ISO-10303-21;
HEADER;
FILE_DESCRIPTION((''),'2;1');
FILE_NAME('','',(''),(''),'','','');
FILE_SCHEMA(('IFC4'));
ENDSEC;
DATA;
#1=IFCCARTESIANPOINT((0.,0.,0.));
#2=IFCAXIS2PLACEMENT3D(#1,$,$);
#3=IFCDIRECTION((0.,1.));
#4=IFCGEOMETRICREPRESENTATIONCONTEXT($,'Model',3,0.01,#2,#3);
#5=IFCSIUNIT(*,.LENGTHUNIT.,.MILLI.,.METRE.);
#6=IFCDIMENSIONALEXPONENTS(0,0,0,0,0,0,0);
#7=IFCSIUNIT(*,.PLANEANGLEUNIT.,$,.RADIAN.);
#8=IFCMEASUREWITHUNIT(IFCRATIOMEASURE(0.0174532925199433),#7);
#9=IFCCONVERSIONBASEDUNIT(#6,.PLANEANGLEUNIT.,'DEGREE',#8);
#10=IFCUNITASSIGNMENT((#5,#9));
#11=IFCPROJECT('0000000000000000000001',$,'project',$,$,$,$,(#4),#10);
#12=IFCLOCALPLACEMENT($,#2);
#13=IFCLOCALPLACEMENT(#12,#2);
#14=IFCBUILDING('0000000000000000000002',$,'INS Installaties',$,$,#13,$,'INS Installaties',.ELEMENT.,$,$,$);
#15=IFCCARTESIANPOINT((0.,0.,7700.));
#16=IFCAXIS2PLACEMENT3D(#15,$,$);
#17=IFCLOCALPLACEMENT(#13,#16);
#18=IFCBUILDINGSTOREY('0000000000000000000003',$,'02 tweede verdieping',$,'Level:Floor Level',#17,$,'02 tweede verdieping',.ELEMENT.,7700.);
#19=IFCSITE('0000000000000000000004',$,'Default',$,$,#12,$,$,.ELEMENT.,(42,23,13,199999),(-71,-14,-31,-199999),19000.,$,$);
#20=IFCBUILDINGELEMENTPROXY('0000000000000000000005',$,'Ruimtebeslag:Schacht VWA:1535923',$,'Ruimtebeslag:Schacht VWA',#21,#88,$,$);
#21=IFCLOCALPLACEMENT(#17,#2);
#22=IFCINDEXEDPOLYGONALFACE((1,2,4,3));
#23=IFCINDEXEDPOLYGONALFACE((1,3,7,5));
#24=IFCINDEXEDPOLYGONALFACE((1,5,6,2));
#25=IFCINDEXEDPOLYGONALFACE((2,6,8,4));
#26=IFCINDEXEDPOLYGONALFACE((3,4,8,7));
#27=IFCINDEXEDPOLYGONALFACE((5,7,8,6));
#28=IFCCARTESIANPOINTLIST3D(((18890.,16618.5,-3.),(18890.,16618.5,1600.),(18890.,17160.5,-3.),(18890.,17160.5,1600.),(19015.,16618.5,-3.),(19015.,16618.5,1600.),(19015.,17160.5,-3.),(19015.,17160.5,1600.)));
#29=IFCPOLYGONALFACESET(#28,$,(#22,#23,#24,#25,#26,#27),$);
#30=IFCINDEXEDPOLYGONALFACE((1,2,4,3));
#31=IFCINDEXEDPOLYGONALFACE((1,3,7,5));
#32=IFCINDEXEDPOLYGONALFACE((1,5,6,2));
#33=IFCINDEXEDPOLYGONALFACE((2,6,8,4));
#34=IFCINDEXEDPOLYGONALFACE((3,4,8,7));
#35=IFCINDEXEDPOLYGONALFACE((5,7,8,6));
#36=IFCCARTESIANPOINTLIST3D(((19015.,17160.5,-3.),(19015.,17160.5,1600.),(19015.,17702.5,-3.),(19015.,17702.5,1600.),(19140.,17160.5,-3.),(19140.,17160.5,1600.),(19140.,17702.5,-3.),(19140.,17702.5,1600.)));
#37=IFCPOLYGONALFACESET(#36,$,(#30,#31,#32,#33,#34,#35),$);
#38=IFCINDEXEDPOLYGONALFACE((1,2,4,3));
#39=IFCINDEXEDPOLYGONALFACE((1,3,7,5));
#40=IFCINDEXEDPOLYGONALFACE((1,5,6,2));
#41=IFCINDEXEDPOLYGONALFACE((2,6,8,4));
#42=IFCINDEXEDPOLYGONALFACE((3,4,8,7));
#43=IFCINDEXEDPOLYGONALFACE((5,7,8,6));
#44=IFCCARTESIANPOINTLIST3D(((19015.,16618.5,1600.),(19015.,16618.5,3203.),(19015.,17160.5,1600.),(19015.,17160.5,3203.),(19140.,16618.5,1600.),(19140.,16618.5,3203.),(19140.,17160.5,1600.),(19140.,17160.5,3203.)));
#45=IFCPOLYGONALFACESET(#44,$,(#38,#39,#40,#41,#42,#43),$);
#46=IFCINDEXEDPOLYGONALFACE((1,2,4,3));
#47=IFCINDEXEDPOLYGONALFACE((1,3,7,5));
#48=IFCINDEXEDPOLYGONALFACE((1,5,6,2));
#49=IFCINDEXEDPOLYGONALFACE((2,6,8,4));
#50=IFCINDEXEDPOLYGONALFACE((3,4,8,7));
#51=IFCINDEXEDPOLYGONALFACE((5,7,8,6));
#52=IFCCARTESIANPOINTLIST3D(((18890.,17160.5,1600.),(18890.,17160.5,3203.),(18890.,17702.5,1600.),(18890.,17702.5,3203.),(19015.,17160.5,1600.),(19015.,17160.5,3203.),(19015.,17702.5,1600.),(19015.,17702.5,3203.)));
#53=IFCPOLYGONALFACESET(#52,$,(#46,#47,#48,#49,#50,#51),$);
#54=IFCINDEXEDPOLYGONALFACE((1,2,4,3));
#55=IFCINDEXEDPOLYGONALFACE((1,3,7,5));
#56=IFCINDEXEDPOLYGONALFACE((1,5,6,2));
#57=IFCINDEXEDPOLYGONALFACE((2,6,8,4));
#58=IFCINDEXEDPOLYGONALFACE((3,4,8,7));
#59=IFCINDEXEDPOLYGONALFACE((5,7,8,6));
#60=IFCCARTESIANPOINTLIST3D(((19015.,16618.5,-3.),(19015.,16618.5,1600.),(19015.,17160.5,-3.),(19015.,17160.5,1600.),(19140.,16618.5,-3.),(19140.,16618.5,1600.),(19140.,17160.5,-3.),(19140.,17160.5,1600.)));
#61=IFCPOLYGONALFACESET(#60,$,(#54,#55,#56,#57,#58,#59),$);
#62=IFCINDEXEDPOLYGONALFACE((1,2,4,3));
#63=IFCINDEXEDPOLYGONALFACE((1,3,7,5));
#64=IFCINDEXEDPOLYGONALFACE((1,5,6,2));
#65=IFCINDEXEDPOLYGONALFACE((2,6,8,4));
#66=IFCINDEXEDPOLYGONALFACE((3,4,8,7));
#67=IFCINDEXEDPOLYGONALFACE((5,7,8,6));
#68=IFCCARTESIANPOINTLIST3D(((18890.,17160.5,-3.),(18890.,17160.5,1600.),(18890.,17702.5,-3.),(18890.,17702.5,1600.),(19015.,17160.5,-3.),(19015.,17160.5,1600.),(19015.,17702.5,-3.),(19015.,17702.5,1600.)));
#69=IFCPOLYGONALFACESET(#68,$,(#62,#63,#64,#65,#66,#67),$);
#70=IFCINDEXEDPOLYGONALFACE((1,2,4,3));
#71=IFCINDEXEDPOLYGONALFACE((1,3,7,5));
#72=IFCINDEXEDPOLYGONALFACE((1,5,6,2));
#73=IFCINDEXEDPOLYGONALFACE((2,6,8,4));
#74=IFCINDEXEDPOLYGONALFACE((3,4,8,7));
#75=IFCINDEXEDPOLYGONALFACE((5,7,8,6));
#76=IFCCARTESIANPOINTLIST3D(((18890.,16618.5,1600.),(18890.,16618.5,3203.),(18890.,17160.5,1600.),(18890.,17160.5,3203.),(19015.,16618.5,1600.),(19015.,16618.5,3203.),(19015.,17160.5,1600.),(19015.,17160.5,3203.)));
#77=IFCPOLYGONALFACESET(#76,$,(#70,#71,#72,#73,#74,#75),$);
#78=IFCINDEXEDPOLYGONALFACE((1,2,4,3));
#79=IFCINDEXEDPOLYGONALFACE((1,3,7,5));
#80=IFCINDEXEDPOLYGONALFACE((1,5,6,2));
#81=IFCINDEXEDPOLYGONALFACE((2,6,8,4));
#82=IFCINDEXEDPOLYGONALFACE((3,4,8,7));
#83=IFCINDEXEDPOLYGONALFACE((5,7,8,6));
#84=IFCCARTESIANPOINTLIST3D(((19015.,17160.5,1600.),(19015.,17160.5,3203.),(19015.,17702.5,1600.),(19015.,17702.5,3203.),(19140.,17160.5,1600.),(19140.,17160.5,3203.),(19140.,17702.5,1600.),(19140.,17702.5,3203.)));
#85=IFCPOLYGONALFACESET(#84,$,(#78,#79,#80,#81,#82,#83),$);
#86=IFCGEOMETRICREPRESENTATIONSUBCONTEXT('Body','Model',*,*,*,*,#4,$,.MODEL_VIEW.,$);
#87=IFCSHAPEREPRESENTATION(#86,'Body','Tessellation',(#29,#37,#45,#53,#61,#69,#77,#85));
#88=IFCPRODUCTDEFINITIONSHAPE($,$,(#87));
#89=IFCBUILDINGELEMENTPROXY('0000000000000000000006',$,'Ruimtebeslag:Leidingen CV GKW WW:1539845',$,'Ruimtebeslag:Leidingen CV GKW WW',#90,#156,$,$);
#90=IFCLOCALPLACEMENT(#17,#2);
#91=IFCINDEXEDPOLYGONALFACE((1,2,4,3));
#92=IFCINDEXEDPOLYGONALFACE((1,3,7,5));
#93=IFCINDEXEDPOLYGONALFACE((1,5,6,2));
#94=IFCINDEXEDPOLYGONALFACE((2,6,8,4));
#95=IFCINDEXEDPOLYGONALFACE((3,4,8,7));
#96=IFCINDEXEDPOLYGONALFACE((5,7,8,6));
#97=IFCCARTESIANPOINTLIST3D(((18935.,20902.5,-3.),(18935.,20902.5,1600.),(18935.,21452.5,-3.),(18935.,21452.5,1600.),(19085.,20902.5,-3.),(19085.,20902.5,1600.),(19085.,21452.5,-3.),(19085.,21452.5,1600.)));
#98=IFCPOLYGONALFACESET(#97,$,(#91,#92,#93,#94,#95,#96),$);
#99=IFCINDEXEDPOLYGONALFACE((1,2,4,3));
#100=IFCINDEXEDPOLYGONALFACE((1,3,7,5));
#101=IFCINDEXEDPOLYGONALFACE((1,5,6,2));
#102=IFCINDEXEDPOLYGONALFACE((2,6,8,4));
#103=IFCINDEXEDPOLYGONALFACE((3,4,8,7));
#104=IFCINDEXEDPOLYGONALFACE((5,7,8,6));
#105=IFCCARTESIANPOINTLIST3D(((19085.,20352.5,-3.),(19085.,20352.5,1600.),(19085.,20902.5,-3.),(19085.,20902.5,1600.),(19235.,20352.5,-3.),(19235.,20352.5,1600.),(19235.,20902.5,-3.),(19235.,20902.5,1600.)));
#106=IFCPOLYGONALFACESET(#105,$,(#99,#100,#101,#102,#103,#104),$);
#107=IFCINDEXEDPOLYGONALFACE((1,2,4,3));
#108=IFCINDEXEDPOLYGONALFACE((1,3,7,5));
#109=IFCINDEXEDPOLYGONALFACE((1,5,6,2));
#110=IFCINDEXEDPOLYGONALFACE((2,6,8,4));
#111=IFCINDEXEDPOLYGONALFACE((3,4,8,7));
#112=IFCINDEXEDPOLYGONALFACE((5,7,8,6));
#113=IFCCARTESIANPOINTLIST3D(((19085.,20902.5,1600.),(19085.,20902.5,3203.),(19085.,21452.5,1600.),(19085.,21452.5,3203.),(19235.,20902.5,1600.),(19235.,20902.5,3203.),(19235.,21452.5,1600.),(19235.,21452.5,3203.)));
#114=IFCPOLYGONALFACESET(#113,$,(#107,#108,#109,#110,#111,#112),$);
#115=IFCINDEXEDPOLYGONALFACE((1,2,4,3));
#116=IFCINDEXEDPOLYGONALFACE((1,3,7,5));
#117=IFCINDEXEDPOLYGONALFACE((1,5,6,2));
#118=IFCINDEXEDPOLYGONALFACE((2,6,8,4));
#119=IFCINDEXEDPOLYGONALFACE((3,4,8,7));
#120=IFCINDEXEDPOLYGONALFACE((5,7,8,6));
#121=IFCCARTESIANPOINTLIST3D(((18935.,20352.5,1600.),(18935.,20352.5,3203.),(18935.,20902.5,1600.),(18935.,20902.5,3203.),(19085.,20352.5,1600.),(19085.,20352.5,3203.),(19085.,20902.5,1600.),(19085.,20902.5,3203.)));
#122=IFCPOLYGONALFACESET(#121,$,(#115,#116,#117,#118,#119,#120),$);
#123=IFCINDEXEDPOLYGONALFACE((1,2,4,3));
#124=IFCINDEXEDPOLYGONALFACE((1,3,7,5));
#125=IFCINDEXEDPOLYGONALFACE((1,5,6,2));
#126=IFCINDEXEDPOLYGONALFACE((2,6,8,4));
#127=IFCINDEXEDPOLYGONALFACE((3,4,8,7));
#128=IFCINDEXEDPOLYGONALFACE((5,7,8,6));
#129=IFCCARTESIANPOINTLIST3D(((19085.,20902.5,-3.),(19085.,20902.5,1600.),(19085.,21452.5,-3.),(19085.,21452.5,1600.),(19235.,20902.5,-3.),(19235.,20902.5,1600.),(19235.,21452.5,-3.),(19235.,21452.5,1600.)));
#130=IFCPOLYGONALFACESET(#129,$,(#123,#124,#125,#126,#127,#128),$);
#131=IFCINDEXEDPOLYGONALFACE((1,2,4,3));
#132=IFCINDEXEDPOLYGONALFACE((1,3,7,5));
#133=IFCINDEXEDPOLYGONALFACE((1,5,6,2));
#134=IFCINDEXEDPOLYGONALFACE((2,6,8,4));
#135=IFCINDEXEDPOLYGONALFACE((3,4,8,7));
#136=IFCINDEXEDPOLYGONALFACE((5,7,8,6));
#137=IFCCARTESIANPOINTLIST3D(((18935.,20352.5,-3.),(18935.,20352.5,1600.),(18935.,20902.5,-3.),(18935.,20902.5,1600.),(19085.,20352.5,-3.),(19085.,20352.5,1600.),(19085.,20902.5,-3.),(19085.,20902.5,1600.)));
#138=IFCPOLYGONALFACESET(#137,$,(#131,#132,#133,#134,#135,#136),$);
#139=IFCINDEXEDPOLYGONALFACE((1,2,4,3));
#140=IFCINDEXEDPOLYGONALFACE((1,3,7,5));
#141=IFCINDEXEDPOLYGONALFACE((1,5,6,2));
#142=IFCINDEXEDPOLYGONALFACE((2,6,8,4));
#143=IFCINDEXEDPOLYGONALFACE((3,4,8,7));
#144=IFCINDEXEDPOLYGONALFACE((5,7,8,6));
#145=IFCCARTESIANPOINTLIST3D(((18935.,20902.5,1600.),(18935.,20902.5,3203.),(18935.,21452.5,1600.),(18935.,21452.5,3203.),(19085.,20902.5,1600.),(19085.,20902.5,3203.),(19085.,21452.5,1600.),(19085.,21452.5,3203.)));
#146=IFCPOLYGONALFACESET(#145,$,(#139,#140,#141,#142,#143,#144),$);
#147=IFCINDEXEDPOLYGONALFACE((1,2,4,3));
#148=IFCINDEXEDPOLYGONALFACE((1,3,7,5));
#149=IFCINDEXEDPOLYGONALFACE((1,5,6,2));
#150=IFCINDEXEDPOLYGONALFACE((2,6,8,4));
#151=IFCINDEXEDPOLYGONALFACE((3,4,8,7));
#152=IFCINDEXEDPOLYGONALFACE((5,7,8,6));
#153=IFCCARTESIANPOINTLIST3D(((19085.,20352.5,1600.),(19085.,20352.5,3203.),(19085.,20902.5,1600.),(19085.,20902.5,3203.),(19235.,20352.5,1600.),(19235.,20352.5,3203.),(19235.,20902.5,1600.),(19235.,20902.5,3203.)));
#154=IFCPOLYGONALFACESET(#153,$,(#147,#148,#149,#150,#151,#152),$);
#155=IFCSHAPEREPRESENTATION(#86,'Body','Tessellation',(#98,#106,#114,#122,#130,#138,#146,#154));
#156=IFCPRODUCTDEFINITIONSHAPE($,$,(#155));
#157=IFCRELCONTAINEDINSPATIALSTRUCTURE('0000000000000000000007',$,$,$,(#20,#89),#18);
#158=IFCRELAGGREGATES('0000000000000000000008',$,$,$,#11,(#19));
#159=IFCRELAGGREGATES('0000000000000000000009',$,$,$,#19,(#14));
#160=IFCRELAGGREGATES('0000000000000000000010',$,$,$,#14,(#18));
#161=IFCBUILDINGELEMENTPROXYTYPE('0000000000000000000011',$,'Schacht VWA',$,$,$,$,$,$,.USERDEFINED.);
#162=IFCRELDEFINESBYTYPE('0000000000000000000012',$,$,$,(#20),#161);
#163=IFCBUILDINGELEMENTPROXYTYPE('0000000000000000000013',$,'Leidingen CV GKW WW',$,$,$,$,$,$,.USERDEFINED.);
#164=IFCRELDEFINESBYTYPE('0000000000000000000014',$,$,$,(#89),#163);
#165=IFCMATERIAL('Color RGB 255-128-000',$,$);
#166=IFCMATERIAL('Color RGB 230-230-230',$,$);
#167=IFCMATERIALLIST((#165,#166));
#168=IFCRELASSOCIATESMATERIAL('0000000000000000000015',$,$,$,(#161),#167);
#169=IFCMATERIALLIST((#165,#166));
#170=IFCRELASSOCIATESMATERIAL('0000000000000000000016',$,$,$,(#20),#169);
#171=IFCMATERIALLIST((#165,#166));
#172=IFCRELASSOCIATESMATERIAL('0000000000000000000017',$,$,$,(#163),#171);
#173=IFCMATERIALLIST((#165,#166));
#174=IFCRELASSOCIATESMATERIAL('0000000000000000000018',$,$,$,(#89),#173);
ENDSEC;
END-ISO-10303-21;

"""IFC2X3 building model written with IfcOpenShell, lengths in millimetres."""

from ifc_helpers import new_model, entity, si_unit, converted_unit, direction, frame, frame_2d, origin, origin_2d_with_axis, place, context, subcontext, project, spatial, rectangle, extrude, source, transform, mapped, material, material_list, type_object, type_shapes, element, save


model = new_model("IFC2X3")

# Units and contexts
model_context = context("Model", 3, precision=0.01, world=origin(), true_north=direction((0.0, 1.0)))
body_context = subcontext(model_context, "Body", "Model", "MODEL_VIEW")
ifc_project = project(units=[si_unit("LENGTHUNIT", "METRE", prefix="MILLI"), converted_unit("PLANEANGLEUNIT", "DEGREE", entity("IfcRatioMeasure", 0.0174532925199433), si_unit("PLANEANGLEUNIT", "RADIAN"), dimensions=[0, 0, 0, 0, 0, 0, 0])], contexts=[model_context])

# Site, building, storey
site_placement = place(None, origin())
site = spatial("IfcSite", under=ifc_project, at=site_placement, Name="Default", CompositionType="ELEMENT", RefLatitude=(42, 23, 13, 199999), RefLongitude=(-71, -14, -31, -199999), RefElevation=19000.0)
building_placement = place(site_placement, origin())
building = spatial("IfcBuilding", under=site, at=building_placement, Name="INS Installaties", LongName="INS Installaties", CompositionType="ELEMENT")
storey_placement = place(building_placement, frame((0.0, 0.0, 7700.0)))
storey = spatial("IfcBuildingStorey", under=building, at=storey_placement, Name="02 tweede verdieping", ObjectType="Level:Floor Level", LongName="02 tweede verdieping", CompositionType="ELEMENT", Elevation=7700.0)

# Building element proxies
ifc_material_1 = material(Name="Color RGB 255-128-000")
ifc_material_2 = material(Name="Color RGB 230-230-230")
ifc_material_list_1 = material_list([ifc_material_1, ifc_material_2])
ifc_material_list_2 = material_list([ifc_material_1, ifc_material_2])
building_element_proxy_type_1 = type_object("IfcBuildingElementProxyType", Name="Schacht VWA", PredefinedType="USERDEFINED", material=ifc_material_list_2)
shared_shape_1 = source(origin(), body_context, "Body", "SweptSolid", [
    extrude(rectangle(XDim=542.0, YDim=125.0, at=frame_2d((0.0, 0.0), x_axis=(1.0, 0.0))), frame((62.5, 271.0, -3203.0), z_axis=(0.0, 0.0, 1.0), x_axis=(0.0, -1.0, 0.0)), (0.0, 0.0, 1.0), 1603.0),
    extrude(rectangle(XDim=542.0, YDim=125.0, at=origin_2d_with_axis()), frame((-62.5, -271.0, -3203.0), z_axis=(0.0, 0.0, 1.0), x_axis=(0.0, 1.0, 0.0)), (0.0, 0.0, 1.0), 1603.0),
    extrude(rectangle(XDim=125.0, YDim=542.0, at=frame_2d((0.0, 0.0), x_axis=(1.0, 0.0))), frame((-62.5, 271.0, -1600.0), z_axis=(0.0, 0.0, 1.0), x_axis=(-1.0, 0.0, 0.0)), (0.0, 0.0, 1.0), 1603.0),
    extrude(rectangle(XDim=125.0, YDim=542.0, at=frame_2d((0.0, 0.0), x_axis=(1.0, 0.0))), frame((62.5, -271.0, -1600.0)), (0.0, 0.0, 1.0), 1603.0),
    extrude(rectangle(XDim=125.0, YDim=542.0, at=frame_2d((0.0, 0.0), x_axis=(1.0, 0.0))), frame((-62.5, 271.0, -3203.0), z_axis=(0.0, 0.0, 1.0), x_axis=(-1.0, 0.0, 0.0)), (0.0, 0.0, 1.0), 1603.0),
    extrude(rectangle(XDim=125.0, YDim=542.0, at=frame_2d((0.0, 0.0), x_axis=(1.0, 0.0))), frame((62.5, -271.0, -3203.0)), (0.0, 0.0, 1.0), 1603.0),
    extrude(rectangle(XDim=542.0, YDim=125.0, at=origin_2d_with_axis()), frame((62.5, 271.0, -1600.0), z_axis=(0.0, 0.0, 1.0), x_axis=(0.0, -1.0, 0.0)), (0.0, 0.0, 1.0), 1603.0),
    extrude(rectangle(XDim=542.0, YDim=125.0, at=origin_2d_with_axis()), frame((-62.5, -271.0, -1600.0), z_axis=(0.0, 0.0, 1.0), x_axis=(0.0, 1.0, 0.0)), (0.0, 0.0, 1.0), 1603.0),
])
type_shapes(building_element_proxy_type_1, [shared_shape_1])
proxy_1_placement = place(storey_placement, frame((19015.0, 17160.5, 3200.0), z_axis=(0.0, 0.0, 1.0), x_axis=(-1.0, 0.0, 0.0)))
element("IfcBuildingElementProxy", 1, at=proxy_1_placement, inside=storey, type_object=building_element_proxy_type_1, material=ifc_material_list_1, Name="Ruimtebeslag:Schacht VWA:1535923", ObjectType="Ruimtebeslag:Schacht VWA", context=body_context, shape_type="MappedRepresentation", body=[
    mapped(shared_shape_1, transform((0.0, 0.0, 0.0), scale=1.0)),
])
ifc_material_list_3 = material_list([ifc_material_1, ifc_material_2])
ifc_material_list_4 = material_list([ifc_material_1, ifc_material_2])
building_element_proxy_type_2 = type_object("IfcBuildingElementProxyType", Name="Leidingen CV GKW WW", PredefinedType="USERDEFINED", material=ifc_material_list_4)
shared_shape_2 = source(origin(), body_context, "Body", "SweptSolid", [
    extrude(rectangle(XDim=150.0, YDim=550.0, at=frame_2d((0.0, 0.0), x_axis=(1.0, 0.0))), frame((75.0, -275.0, -3203.0)), (0.0, 0.0, 1.0), 1603.0),
    extrude(rectangle(XDim=150.0, YDim=550.0, at=origin_2d_with_axis()), frame((-75.0, 275.0, -3203.0), z_axis=(0.0, 0.0, 1.0), x_axis=(-1.0, 0.0, 0.0)), (0.0, 0.0, 1.0), 1603.0),
    extrude(rectangle(XDim=550.0, YDim=150.0, at=frame_2d((0.0, 0.0), x_axis=(1.0, 0.0))), frame((-75.0, -275.0, -1600.0), z_axis=(0.0, 0.0, 1.0), x_axis=(0.0, 1.0, 0.0)), (0.0, 0.0, 1.0), 1603.0),
    extrude(rectangle(XDim=550.0, YDim=150.0, at=origin_2d_with_axis()), frame((75.0, 275.0, -1600.0), z_axis=(0.0, 0.0, 1.0), x_axis=(0.0, -1.0, 0.0)), (0.0, 0.0, 1.0), 1603.0),
    extrude(rectangle(XDim=550.0, YDim=150.0, at=origin_2d_with_axis()), frame((-75.0, -275.0, -3203.0), z_axis=(0.0, 0.0, 1.0), x_axis=(0.0, 1.0, 0.0)), (0.0, 0.0, 1.0), 1603.0),
    extrude(rectangle(XDim=550.0, YDim=150.0, at=origin_2d_with_axis()), frame((75.0, 275.0, -3203.0), z_axis=(0.0, 0.0, 1.0), x_axis=(0.0, -1.0, 0.0)), (0.0, 0.0, 1.0), 1603.0),
    extrude(rectangle(XDim=150.0, YDim=550.0, at=frame_2d((0.0, 0.0), x_axis=(1.0, 0.0))), frame((75.0, -275.0, -1600.0)), (0.0, 0.0, 1.0), 1603.0),
    extrude(rectangle(XDim=150.0, YDim=550.0, at=origin_2d_with_axis()), frame((-75.0, 275.0, -1600.0), z_axis=(0.0, 0.0, 1.0), x_axis=(-1.0, 0.0, 0.0)), (0.0, 0.0, 1.0), 1603.0),
])
type_shapes(building_element_proxy_type_2, [shared_shape_2])
proxy_2_placement = place(storey_placement, frame((19085.0, 20902.5, 3200.0), z_axis=(0.0, 0.0, 1.0), x_axis=(-1.0, 0.0, 0.0)))
element("IfcBuildingElementProxy", 2, at=proxy_2_placement, inside=storey, type_object=building_element_proxy_type_2, material=ifc_material_list_3, Name="Ruimtebeslag:Leidingen CV GKW WW:1539845", ObjectType="Ruimtebeslag:Leidingen CV GKW WW", context=body_context, shape_type="MappedRepresentation", body=[
    mapped(shared_shape_2, transform((0.0, 0.0, 0.0), scale=1.0)),
])

save(model, "model.ifc")
